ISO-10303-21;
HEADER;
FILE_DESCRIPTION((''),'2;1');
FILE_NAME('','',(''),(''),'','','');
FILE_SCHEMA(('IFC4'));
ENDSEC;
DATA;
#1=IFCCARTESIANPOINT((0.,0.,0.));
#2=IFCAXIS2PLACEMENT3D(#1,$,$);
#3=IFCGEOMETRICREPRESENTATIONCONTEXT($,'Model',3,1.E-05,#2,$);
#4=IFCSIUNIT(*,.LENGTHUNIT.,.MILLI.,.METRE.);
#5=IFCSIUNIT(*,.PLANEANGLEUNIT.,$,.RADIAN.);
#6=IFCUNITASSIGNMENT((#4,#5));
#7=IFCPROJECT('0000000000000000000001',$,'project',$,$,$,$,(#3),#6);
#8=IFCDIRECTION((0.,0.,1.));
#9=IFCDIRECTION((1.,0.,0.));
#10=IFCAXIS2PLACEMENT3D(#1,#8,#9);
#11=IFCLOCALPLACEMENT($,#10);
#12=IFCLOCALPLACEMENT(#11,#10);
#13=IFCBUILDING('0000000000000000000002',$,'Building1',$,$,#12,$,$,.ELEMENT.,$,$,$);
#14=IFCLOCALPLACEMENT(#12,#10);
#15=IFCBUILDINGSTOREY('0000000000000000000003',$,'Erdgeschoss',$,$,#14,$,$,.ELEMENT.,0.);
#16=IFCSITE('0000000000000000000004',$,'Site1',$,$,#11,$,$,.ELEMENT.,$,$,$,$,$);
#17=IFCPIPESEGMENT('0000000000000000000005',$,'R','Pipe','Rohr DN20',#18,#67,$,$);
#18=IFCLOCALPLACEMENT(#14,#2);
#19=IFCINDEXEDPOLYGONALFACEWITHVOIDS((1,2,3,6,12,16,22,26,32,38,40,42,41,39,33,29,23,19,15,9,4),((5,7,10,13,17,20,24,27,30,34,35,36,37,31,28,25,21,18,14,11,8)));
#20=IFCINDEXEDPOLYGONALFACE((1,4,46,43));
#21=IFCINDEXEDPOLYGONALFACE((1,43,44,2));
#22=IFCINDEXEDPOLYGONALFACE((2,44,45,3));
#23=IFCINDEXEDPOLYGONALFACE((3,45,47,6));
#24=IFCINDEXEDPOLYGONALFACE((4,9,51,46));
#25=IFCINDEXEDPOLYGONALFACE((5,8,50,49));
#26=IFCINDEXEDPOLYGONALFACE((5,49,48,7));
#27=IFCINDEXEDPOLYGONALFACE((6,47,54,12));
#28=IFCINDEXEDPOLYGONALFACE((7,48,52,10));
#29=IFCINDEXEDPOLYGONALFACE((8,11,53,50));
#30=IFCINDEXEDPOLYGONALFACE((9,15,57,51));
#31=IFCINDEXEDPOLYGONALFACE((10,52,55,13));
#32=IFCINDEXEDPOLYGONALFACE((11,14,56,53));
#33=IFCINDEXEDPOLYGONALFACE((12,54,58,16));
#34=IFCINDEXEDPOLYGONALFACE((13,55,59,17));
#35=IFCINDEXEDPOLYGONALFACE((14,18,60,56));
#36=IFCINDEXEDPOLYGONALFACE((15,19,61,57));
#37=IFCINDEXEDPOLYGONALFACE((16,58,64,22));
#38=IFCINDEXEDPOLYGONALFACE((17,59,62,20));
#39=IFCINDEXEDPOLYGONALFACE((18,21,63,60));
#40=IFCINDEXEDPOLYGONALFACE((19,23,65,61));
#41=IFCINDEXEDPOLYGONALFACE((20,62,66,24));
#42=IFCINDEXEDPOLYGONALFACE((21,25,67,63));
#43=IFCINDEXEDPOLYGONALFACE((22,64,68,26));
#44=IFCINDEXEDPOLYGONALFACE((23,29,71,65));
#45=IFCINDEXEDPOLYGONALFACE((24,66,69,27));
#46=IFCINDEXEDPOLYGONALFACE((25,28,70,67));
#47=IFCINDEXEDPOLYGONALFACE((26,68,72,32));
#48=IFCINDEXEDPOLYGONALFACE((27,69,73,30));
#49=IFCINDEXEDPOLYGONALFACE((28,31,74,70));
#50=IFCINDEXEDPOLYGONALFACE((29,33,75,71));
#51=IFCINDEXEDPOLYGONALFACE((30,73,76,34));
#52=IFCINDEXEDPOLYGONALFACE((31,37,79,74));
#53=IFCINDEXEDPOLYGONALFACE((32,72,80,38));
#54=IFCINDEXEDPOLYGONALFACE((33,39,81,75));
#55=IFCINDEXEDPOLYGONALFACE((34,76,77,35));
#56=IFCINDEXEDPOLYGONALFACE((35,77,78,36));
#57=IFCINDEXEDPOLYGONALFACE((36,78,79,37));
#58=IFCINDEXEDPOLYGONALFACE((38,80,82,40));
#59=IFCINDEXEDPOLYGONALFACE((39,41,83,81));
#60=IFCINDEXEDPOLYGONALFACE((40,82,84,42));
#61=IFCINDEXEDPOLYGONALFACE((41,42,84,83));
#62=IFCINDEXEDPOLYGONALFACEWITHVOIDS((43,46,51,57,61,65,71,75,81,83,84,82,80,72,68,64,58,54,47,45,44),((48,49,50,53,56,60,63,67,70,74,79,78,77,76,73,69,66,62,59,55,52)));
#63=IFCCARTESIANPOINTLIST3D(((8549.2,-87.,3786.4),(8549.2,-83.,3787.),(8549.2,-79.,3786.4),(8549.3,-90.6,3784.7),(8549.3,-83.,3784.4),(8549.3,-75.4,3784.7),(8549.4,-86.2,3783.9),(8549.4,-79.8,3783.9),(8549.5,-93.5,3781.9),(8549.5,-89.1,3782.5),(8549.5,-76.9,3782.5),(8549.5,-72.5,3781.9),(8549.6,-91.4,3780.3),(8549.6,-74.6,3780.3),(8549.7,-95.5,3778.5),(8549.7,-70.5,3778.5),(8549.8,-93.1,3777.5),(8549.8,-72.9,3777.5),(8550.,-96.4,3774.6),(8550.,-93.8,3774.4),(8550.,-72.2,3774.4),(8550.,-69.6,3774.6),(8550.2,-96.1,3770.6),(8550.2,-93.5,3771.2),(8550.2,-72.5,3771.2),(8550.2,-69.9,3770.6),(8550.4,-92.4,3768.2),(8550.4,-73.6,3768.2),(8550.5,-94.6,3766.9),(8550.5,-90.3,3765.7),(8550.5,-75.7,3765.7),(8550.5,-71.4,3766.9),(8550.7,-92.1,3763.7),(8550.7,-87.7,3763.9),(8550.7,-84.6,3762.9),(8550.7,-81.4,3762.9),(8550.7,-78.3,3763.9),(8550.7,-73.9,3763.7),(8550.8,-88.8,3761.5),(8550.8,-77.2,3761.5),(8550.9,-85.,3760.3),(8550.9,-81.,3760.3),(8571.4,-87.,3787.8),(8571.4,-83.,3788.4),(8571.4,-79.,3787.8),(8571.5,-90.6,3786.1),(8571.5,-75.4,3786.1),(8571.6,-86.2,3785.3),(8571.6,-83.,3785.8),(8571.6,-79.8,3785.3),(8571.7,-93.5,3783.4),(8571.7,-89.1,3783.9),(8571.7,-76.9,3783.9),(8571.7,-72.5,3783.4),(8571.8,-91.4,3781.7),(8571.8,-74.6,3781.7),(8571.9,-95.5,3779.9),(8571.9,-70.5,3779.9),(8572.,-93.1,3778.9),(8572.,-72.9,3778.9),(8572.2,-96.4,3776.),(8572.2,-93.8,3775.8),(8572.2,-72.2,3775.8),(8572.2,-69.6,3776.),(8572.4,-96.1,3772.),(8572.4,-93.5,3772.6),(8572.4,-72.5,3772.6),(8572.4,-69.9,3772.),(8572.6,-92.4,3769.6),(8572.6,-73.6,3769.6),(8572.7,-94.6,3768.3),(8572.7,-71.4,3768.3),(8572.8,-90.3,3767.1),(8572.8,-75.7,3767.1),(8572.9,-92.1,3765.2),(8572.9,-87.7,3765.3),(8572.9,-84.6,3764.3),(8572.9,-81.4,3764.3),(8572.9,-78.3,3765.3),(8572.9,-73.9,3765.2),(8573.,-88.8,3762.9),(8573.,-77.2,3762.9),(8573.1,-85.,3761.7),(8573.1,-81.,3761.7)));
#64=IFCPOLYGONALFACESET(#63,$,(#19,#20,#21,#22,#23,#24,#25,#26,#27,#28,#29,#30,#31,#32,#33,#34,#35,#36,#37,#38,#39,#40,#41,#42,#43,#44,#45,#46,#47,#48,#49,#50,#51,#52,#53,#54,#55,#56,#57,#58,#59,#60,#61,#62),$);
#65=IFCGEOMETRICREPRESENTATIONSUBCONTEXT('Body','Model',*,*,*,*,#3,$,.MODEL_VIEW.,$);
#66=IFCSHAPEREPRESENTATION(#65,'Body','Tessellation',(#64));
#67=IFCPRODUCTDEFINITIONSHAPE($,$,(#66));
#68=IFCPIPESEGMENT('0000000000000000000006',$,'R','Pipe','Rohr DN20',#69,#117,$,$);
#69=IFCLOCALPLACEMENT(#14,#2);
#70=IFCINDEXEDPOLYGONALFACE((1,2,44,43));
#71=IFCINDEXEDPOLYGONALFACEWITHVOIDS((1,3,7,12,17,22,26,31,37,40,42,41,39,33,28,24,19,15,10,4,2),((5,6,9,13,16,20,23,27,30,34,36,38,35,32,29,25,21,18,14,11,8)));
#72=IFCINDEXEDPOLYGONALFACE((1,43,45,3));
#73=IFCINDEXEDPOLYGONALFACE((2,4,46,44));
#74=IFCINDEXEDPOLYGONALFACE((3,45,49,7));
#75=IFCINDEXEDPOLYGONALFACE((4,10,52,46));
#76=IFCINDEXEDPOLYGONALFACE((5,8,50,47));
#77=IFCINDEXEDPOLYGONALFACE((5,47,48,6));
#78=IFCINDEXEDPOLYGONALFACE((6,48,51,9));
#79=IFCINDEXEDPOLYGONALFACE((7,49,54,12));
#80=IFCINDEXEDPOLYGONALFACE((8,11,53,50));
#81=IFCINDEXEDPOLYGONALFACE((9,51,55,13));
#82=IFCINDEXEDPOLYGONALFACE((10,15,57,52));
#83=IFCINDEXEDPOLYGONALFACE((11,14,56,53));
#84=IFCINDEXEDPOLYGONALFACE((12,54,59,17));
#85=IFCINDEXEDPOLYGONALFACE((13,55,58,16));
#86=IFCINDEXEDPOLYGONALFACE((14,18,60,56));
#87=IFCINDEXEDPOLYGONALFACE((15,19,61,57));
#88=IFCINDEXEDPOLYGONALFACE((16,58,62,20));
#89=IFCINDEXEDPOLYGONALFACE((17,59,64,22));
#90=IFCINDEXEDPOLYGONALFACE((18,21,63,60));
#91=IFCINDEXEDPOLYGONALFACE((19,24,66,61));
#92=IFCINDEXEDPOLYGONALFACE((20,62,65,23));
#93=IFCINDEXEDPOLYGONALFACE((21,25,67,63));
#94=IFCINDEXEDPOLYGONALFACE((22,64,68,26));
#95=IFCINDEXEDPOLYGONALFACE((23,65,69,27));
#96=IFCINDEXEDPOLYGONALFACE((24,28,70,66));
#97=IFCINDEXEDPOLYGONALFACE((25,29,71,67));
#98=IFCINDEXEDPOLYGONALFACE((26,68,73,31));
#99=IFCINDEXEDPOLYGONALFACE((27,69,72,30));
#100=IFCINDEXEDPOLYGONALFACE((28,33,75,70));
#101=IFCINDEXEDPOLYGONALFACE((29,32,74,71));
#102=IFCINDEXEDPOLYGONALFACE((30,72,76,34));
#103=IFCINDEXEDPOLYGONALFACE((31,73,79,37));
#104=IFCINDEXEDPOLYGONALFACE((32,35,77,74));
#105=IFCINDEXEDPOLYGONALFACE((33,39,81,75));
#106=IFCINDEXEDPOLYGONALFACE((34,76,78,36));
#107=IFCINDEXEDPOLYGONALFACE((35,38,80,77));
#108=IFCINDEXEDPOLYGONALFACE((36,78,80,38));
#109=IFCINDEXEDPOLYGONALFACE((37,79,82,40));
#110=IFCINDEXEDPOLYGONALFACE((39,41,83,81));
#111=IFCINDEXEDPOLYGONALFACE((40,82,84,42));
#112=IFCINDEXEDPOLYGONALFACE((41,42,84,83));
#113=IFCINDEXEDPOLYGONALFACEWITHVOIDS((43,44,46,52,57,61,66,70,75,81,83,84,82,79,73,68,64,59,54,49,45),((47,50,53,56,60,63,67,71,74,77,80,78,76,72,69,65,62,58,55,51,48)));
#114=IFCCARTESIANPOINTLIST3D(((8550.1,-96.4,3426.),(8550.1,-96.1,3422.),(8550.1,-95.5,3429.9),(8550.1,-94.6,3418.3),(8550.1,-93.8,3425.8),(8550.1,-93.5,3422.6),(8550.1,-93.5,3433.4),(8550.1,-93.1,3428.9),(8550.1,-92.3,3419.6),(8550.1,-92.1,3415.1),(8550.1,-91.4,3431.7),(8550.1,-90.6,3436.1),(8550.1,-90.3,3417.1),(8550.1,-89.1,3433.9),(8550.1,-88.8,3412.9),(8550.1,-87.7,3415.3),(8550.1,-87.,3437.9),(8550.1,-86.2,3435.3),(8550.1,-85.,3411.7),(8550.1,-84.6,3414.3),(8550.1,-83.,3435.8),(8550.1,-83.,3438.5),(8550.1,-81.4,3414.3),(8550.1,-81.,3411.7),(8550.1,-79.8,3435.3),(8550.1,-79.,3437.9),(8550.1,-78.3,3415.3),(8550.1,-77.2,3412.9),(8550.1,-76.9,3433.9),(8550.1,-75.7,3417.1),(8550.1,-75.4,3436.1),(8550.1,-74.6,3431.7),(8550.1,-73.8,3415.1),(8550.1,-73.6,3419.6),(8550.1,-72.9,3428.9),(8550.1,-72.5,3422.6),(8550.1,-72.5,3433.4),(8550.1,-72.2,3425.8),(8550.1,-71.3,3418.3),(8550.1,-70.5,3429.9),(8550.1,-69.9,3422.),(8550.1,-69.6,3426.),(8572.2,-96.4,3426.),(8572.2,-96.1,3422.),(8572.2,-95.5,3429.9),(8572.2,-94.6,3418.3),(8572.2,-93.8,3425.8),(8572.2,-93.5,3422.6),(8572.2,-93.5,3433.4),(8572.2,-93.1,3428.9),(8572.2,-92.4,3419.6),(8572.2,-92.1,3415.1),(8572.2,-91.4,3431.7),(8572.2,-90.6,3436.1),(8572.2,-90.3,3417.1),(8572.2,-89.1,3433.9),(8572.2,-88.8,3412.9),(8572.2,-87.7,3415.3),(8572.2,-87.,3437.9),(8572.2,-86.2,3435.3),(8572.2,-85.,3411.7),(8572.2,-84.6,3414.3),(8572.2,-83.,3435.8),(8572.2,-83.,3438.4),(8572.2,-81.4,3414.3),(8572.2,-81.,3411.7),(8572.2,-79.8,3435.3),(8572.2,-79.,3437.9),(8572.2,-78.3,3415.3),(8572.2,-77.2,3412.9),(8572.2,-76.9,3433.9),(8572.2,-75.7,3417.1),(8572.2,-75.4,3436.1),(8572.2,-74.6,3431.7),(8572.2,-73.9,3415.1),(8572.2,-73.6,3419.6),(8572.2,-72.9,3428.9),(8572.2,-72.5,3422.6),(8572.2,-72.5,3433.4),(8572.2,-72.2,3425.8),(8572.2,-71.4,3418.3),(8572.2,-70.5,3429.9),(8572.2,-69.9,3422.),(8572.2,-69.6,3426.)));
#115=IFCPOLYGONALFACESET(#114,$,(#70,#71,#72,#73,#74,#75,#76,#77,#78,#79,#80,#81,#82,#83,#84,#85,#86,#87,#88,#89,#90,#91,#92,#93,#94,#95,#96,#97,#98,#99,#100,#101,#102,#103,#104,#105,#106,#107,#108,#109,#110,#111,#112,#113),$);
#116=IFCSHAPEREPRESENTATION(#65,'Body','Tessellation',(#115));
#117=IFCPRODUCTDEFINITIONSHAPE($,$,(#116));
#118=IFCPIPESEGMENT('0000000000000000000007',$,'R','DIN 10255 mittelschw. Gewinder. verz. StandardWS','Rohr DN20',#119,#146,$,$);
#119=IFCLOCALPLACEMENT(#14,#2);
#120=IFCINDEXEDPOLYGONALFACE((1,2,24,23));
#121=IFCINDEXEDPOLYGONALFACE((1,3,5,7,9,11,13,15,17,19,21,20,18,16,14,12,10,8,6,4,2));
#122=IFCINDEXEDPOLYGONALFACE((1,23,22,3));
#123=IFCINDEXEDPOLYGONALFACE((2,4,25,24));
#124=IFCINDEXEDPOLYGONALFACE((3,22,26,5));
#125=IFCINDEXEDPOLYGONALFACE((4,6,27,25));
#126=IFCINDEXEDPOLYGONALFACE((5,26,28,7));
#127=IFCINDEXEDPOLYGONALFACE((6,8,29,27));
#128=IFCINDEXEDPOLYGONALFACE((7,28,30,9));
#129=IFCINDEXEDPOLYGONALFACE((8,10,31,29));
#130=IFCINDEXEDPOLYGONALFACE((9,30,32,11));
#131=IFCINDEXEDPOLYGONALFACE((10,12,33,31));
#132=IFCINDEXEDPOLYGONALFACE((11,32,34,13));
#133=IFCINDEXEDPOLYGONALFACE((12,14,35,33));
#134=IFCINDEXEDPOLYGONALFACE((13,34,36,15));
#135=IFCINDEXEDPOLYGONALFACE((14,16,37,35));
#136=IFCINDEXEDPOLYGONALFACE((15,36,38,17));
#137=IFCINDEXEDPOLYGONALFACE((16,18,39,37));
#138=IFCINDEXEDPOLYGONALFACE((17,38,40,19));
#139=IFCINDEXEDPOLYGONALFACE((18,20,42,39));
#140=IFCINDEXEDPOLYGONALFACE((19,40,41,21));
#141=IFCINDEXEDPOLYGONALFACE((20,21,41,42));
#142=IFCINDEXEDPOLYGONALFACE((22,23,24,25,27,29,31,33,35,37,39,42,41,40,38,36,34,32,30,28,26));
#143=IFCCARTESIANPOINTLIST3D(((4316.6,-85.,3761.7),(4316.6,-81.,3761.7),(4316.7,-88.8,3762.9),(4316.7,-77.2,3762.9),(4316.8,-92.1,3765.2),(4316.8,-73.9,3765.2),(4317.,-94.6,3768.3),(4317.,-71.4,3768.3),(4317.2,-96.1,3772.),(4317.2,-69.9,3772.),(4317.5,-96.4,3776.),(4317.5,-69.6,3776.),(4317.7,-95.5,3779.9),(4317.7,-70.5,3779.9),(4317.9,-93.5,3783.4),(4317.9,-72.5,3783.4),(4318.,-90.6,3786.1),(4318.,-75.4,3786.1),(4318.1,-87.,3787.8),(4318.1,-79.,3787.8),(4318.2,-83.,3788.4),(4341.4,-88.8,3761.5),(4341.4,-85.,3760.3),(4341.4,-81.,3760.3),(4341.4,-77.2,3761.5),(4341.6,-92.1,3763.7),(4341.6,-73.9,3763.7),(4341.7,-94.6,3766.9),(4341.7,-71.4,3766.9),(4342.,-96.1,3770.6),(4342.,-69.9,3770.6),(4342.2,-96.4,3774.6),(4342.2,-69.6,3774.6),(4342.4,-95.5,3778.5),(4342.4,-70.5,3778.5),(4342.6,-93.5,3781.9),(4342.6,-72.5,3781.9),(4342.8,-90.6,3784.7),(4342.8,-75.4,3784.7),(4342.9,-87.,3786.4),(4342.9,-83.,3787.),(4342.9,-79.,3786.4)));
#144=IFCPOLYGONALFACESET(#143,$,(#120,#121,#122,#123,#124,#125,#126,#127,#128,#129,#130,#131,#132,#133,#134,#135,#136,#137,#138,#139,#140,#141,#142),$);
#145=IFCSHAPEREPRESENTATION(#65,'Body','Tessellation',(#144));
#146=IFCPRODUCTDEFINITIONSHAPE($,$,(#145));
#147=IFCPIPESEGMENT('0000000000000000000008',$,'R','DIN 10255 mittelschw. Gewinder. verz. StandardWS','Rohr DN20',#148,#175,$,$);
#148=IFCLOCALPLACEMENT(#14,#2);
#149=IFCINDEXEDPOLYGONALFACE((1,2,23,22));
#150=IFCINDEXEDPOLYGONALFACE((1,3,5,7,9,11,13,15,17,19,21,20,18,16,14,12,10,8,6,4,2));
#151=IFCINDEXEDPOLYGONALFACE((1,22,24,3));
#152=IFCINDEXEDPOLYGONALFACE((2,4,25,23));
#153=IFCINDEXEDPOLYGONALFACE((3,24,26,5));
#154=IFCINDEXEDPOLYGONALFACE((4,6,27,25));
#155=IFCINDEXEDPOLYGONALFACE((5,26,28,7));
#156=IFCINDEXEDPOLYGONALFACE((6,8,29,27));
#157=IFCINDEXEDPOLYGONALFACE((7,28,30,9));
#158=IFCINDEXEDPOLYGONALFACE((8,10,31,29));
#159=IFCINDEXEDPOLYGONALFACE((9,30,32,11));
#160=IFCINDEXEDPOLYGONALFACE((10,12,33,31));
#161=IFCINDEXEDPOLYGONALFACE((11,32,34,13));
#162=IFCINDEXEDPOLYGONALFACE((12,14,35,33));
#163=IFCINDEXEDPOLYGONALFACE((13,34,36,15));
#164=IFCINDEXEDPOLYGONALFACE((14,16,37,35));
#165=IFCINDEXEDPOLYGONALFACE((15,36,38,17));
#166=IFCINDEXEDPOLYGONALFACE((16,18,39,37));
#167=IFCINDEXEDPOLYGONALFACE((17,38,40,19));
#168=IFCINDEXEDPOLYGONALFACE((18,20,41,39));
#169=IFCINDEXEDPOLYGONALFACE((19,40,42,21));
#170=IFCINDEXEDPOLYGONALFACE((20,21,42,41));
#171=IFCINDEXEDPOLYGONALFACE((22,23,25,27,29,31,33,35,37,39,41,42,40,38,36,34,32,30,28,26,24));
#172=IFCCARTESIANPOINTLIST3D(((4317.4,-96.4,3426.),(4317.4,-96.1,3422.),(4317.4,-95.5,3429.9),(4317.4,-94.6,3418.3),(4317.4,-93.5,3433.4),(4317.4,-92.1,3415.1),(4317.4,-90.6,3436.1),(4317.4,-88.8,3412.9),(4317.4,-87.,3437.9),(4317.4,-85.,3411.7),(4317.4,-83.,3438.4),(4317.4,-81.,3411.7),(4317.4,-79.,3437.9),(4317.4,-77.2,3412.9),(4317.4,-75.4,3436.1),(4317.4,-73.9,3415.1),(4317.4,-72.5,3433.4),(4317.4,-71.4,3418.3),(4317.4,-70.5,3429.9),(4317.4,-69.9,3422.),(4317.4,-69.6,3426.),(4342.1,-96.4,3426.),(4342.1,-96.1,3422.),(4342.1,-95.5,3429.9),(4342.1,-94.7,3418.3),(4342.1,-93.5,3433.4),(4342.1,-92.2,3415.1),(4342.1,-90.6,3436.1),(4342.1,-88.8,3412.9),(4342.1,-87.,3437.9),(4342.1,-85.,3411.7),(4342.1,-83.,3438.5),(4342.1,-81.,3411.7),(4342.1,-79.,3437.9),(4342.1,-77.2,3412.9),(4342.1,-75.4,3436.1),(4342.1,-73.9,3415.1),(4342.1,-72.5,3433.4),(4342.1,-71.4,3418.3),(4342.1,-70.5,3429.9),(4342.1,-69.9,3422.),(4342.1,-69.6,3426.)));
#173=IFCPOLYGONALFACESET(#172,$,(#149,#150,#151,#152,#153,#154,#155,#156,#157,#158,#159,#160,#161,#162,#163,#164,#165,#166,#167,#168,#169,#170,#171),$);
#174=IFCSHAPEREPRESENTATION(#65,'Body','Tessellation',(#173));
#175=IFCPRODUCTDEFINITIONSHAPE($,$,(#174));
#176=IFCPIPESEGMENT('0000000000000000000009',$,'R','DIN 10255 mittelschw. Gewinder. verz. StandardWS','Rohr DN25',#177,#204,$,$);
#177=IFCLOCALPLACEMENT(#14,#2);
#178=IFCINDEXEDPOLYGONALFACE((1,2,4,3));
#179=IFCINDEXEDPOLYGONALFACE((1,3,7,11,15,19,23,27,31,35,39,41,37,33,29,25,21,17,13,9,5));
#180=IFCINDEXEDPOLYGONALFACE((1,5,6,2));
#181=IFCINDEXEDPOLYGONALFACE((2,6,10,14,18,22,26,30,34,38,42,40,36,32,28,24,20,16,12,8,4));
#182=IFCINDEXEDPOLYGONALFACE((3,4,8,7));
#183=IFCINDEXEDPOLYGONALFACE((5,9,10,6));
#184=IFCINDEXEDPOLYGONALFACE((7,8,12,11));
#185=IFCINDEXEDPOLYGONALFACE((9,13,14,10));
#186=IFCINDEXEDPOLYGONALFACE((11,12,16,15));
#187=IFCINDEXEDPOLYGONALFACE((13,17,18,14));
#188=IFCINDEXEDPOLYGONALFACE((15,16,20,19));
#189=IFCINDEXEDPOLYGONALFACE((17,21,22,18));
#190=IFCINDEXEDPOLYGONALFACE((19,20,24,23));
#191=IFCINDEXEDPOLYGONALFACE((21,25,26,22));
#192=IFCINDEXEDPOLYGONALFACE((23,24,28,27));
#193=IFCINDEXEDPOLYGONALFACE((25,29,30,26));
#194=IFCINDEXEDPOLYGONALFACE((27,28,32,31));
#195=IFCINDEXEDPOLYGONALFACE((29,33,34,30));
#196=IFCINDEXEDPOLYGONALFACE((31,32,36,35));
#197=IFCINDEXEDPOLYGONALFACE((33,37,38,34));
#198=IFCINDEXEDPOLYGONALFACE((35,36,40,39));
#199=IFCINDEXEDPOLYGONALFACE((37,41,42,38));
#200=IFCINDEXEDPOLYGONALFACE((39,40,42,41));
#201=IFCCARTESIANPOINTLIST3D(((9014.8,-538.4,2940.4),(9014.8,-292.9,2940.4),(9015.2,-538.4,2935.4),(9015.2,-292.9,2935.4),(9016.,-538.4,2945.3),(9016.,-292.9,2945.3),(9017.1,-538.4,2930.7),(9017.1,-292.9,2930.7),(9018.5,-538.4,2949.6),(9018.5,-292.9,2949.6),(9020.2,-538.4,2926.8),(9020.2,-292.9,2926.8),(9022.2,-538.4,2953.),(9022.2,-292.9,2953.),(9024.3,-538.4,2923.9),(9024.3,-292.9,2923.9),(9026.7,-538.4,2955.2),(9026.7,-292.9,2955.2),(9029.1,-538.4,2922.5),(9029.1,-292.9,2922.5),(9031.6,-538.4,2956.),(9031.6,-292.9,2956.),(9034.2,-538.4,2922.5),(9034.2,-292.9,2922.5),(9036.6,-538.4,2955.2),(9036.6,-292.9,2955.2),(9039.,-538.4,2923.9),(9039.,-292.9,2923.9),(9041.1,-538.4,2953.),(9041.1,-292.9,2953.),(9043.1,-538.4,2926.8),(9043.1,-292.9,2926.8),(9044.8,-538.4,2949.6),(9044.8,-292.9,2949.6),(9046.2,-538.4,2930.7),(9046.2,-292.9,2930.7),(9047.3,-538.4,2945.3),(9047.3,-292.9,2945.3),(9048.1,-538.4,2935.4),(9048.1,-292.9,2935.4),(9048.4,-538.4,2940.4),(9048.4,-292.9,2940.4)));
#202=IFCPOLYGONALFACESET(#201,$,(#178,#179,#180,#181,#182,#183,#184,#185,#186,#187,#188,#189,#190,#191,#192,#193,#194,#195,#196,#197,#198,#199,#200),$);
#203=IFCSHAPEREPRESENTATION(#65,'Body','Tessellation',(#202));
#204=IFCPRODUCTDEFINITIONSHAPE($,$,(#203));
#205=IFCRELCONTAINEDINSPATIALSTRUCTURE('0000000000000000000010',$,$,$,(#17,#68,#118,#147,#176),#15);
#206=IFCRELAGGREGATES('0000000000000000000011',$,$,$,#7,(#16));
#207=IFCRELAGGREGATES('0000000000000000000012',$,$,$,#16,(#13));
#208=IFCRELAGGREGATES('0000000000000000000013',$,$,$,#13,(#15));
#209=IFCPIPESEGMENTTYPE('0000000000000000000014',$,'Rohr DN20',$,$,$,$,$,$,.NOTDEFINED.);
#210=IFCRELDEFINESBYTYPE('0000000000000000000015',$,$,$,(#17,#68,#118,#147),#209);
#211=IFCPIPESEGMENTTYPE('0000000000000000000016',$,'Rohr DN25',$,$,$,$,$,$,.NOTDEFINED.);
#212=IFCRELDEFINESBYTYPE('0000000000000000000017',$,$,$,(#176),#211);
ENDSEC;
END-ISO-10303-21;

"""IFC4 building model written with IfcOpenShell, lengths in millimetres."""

from ifc_helpers import new_model, si_unit, frame, origin, origin_with_axes, origin_2d_with_axis, place, context, subcontext, project, spatial, circle, hollow_circle, extrude, type_object, element, save


model = new_model("IFC4")

# Units and contexts
model_context = context("Model", 3, precision=1e-05, world=origin())
body_context = subcontext(model_context, "Body", "Model", "MODEL_VIEW")
ifc_project = project(units=[si_unit("LENGTHUNIT", "METRE", prefix="MILLI"), si_unit("PLANEANGLEUNIT", "RADIAN")], contexts=[model_context])

# Site, building, storey
site_placement = place(None, origin_with_axes())
site = spatial("IfcSite", under=ifc_project, at=site_placement, Name="Site1", CompositionType="ELEMENT")
building_placement = place(site_placement, origin_with_axes())
building = spatial("IfcBuilding", under=site, at=building_placement, Name="Building1", CompositionType="ELEMENT")
storey_placement = place(building_placement, origin_with_axes())
storey = spatial("IfcBuildingStorey", under=building, at=storey_placement, Name="Erdgeschoss", CompositionType="ELEMENT", Elevation=0.0)

# Pipe segments
pipe_segment_type_1 = type_object("IfcPipeSegmentType", Name="Rohr DN20", PredefinedType="NOTDEFINED")
pipe_segment_1_placement = place(storey_placement, frame((8561.1, -82.8, 3774.3), z_axis=(0.0, 0.0, 1.0), x_axis=(1.0, 0.0, 0.0)))
element("IfcPipeSegment", 1, at=pipe_segment_1_placement, inside=storey, type_object=pipe_segment_type_1, Name="R", Description="Pipe", ObjectType="Rohr DN20", context=body_context, shape_type="SolidModel", body=[
    extrude(hollow_circle(Radius=13.4, WallThickness=2.6, at=origin_2d_with_axis()), frame((-11.1, -0.1, -0.7), z_axis=(0.99795, 0.0, 0.063994), x_axis=(0.0, 0.0, 1.0)), (0.0, 0.0, 1.0), 22.3),
])
pipe_segment_2_placement = place(storey_placement, frame((8561.2, -82.8, 3425.0), z_axis=(0.0, 0.0, 1.0), x_axis=(1.0, 0.0, 0.0)))
element("IfcPipeSegment", 2, at=pipe_segment_2_placement, inside=storey, type_object=pipe_segment_type_1, Name="R", Description="Pipe", ObjectType="Rohr DN20", context=body_context, shape_type="SolidModel", body=[
    extrude(hollow_circle(Radius=13.4, WallThickness=2.6, at=origin_2d_with_axis()), frame((-11.1, -0.1, 0.0), z_axis=(1.0, -0.000148, -0.000106), x_axis=(0.0, 0.0, 1.0)), (0.0, 0.0, 1.0), 22.2),
])
pipe_segment_3_placement = place(storey_placement, frame((4329.8, -83.2, 3774.3), z_axis=(0.0, 0.0, 1.0), x_axis=(1.0, 0.0, 0.0)))
element("IfcPipeSegment", 3, at=pipe_segment_3_placement, inside=storey, type_object=pipe_segment_type_1, Name="R", Description="DIN 10255 mittelschw. Gewinder. verz. StandardWS", ObjectType="Rohr DN20", context=body_context, shape_type="SolidModel", body=[
    extrude(circle(Radius=13.4, at=origin_2d_with_axis()), frame((12.4, 0.1, -0.7), z_axis=(-0.998345, 0.0, 0.057509), x_axis=(0.0, 0.0, 1.0)), (0.0, 0.0, 1.0), 24.8),
])
pipe_segment_4_placement = place(storey_placement, frame((4329.7, -83.2, 3425.0), z_axis=(0.0, 0.0, 1.0), x_axis=(1.0, 0.0, 0.0)))
element("IfcPipeSegment", 4, at=pipe_segment_4_placement, inside=storey, type_object=pipe_segment_type_1, Name="R", Description="DIN 10255 mittelschw. Gewinder. verz. StandardWS", ObjectType="Rohr DN20", context=body_context, shape_type="SolidModel", body=[
    extrude(circle(Radius=13.4, at=origin_2d_with_axis()), frame((12.3, 0.1, 0.0), z_axis=(-1.0, 0.000133, -0.000096), x_axis=(0.0, 0.0, 1.0)), (0.0, 0.0, 1.0), 24.7),
])
pipe_segment_type_2 = type_object("IfcPipeSegmentType", Name="Rohr DN25", PredefinedType="NOTDEFINED")
pipe_segment_5_placement = place(storey_placement, frame((9031.5, -415.6, 2939.1), z_axis=(0.0, 0.0, 1.0), x_axis=(1.0, 0.0, 0.0)))
element("IfcPipeSegment", 5, at=pipe_segment_5_placement, inside=storey, type_object=pipe_segment_type_2, Name="R", Description="DIN 10255 mittelschw. Gewinder. verz. StandardWS", ObjectType="Rohr DN25", context=body_context, shape_type="SolidModel", body=[
    extrude(circle(Radius=16.9, at=origin_2d_with_axis()), frame((0.1, -122.8, 0.0), z_axis=(0.0, 1.0, 0.0), x_axis=(0.0, 0.0, 1.0)), (0.0, 0.0, 1.0), 245.5),
])

save(model, "model.ifc")
